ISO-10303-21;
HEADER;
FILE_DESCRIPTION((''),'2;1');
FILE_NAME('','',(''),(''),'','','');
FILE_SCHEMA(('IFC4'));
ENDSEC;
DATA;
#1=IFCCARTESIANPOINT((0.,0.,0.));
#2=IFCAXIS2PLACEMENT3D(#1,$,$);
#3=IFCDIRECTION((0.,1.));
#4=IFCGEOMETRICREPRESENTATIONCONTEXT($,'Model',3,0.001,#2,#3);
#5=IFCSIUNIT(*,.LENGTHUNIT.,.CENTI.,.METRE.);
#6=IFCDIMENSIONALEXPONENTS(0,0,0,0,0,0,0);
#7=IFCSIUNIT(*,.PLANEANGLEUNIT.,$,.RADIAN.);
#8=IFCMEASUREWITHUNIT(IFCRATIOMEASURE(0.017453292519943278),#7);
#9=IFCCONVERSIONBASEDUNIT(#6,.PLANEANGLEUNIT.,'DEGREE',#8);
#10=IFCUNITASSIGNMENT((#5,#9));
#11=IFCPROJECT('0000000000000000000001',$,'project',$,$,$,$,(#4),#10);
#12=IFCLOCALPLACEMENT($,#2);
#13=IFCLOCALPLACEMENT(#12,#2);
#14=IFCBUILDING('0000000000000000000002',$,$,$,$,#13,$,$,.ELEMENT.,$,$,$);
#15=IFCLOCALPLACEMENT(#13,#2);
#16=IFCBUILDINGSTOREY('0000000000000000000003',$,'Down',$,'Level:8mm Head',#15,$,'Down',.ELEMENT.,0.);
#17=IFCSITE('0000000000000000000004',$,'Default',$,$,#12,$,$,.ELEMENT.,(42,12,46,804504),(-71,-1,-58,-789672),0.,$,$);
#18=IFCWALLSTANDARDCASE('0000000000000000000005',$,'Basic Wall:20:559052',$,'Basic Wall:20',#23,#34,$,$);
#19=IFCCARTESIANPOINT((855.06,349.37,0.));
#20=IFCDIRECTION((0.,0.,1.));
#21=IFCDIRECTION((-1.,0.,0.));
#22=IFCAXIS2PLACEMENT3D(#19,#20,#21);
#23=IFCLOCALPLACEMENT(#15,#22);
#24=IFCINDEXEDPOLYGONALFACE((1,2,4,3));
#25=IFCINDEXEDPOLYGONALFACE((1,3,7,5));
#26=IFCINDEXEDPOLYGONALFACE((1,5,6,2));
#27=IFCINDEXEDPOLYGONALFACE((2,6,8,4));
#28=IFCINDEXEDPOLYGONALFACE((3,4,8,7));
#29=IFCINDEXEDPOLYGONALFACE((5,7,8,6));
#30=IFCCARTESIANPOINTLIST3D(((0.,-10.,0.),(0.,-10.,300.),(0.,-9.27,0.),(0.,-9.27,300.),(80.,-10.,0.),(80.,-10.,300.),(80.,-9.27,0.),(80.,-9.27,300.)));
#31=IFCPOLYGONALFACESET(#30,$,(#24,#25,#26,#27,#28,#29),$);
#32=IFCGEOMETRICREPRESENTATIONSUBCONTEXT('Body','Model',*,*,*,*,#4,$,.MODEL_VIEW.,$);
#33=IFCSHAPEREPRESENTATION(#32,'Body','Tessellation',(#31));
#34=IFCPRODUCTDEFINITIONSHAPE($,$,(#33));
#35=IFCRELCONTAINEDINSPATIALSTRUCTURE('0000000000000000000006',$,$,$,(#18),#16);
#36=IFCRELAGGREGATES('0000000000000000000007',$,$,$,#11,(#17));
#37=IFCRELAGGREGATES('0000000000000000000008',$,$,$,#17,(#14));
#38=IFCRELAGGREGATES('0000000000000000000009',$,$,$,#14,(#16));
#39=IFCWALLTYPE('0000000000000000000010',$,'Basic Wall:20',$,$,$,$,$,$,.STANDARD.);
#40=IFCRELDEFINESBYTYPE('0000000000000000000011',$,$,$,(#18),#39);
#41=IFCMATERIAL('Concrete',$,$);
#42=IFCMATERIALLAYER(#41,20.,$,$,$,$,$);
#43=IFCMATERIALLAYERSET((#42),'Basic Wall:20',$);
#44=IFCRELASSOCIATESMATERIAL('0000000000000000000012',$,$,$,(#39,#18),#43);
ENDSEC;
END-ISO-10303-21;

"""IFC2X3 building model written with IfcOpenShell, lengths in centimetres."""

from ifc_helpers import new_model, entity, si_unit, converted_unit, direction, frame, frame_2d, origin, place, context, subcontext, project, spatial, polyline, rectangle, extrude, clip, bounded_halfspace, material, layer, layer_set, layer_usage, type_object, element, save


model = new_model("IFC2X3")

# Units and contexts
model_context = context("Model", 3, precision=0.001, world=origin(), true_north=direction((0.0, 1.0)))
body_context = subcontext(model_context, "Body", "Model", "MODEL_VIEW")
ifc_project = project(units=[si_unit("LENGTHUNIT", "METRE", prefix="CENTI"), converted_unit("PLANEANGLEUNIT", "DEGREE", entity("IfcRatioMeasure", 0.017453292519943278), si_unit("PLANEANGLEUNIT", "RADIAN"), dimensions=[0, 0, 0, 0, 0, 0, 0])], contexts=[model_context])

# Site, building, storey
site_placement = place(None, origin())
site = spatial("IfcSite", under=ifc_project, at=site_placement, Name="Default", CompositionType="ELEMENT", RefLatitude=(42, 12, 46, 804504), RefLongitude=(-71, -1, -58, -789672), RefElevation=0.0)
building_placement = place(site_placement, origin())
building = spatial("IfcBuilding", under=site, at=building_placement, CompositionType="ELEMENT")
storey_placement = place(building_placement, origin())
storey = spatial("IfcBuildingStorey", under=building, at=storey_placement, Name="Down", ObjectType="Level:8mm Head", LongName="Down", CompositionType="ELEMENT", Elevation=0.0)

# Wall
ifc_material = material(Name="Concrete")
ifc_layer_1 = layer(ifc_material, 20.0)
ifc_layer_set_1 = layer_set([ifc_layer_1], Name="Basic Wall:20")
wall_type_1 = type_object("IfcWallType", Name="Basic Wall:20", PredefinedType="STANDARD", material=ifc_layer_set_1)
ifc_layer_usage_1 = layer_usage(ifc_layer_set_1, "AXIS2", "POSITIVE", -10.0)
wall_1_placement = place(storey_placement, frame((855.06, 349.37, 0.0), z_axis=(0.0, 0.0, 1.0), x_axis=(-1.0, 0.0, 0.0)))
element("IfcWallStandardCase", 1, at=wall_1_placement, inside=storey, type_object=wall_type_1, material=ifc_layer_usage_1, Name="Basic Wall:20:559052", ObjectType="Basic Wall:20", context=body_context, shape_type="Clipping", body=[
    clip(extrude(rectangle(XDim=80.0, YDim=20.0, at=frame_2d((40.0, 0.0), x_axis=(-1.0, 0.0))), origin(), (0.0, 0.0, 1.0), 300.0), bounded_halfspace(frame((80.0, -9.27, 0.0), z_axis=(0.0, -1.0, 0.0), x_axis=(1.0, 0.0, 0.0)), True, frame((80.0, -9.27, 0.0), z_axis=(0.0, -1.0, 0.0), x_axis=(1.0, 0.0, 0.0)), polyline([(0.0, 0.0), (0.0, 300.0), (-80.0, 300.0), (-80.0, 0.0), (0.0, 0.0)]))),
])

save(model, "model.ifc")
